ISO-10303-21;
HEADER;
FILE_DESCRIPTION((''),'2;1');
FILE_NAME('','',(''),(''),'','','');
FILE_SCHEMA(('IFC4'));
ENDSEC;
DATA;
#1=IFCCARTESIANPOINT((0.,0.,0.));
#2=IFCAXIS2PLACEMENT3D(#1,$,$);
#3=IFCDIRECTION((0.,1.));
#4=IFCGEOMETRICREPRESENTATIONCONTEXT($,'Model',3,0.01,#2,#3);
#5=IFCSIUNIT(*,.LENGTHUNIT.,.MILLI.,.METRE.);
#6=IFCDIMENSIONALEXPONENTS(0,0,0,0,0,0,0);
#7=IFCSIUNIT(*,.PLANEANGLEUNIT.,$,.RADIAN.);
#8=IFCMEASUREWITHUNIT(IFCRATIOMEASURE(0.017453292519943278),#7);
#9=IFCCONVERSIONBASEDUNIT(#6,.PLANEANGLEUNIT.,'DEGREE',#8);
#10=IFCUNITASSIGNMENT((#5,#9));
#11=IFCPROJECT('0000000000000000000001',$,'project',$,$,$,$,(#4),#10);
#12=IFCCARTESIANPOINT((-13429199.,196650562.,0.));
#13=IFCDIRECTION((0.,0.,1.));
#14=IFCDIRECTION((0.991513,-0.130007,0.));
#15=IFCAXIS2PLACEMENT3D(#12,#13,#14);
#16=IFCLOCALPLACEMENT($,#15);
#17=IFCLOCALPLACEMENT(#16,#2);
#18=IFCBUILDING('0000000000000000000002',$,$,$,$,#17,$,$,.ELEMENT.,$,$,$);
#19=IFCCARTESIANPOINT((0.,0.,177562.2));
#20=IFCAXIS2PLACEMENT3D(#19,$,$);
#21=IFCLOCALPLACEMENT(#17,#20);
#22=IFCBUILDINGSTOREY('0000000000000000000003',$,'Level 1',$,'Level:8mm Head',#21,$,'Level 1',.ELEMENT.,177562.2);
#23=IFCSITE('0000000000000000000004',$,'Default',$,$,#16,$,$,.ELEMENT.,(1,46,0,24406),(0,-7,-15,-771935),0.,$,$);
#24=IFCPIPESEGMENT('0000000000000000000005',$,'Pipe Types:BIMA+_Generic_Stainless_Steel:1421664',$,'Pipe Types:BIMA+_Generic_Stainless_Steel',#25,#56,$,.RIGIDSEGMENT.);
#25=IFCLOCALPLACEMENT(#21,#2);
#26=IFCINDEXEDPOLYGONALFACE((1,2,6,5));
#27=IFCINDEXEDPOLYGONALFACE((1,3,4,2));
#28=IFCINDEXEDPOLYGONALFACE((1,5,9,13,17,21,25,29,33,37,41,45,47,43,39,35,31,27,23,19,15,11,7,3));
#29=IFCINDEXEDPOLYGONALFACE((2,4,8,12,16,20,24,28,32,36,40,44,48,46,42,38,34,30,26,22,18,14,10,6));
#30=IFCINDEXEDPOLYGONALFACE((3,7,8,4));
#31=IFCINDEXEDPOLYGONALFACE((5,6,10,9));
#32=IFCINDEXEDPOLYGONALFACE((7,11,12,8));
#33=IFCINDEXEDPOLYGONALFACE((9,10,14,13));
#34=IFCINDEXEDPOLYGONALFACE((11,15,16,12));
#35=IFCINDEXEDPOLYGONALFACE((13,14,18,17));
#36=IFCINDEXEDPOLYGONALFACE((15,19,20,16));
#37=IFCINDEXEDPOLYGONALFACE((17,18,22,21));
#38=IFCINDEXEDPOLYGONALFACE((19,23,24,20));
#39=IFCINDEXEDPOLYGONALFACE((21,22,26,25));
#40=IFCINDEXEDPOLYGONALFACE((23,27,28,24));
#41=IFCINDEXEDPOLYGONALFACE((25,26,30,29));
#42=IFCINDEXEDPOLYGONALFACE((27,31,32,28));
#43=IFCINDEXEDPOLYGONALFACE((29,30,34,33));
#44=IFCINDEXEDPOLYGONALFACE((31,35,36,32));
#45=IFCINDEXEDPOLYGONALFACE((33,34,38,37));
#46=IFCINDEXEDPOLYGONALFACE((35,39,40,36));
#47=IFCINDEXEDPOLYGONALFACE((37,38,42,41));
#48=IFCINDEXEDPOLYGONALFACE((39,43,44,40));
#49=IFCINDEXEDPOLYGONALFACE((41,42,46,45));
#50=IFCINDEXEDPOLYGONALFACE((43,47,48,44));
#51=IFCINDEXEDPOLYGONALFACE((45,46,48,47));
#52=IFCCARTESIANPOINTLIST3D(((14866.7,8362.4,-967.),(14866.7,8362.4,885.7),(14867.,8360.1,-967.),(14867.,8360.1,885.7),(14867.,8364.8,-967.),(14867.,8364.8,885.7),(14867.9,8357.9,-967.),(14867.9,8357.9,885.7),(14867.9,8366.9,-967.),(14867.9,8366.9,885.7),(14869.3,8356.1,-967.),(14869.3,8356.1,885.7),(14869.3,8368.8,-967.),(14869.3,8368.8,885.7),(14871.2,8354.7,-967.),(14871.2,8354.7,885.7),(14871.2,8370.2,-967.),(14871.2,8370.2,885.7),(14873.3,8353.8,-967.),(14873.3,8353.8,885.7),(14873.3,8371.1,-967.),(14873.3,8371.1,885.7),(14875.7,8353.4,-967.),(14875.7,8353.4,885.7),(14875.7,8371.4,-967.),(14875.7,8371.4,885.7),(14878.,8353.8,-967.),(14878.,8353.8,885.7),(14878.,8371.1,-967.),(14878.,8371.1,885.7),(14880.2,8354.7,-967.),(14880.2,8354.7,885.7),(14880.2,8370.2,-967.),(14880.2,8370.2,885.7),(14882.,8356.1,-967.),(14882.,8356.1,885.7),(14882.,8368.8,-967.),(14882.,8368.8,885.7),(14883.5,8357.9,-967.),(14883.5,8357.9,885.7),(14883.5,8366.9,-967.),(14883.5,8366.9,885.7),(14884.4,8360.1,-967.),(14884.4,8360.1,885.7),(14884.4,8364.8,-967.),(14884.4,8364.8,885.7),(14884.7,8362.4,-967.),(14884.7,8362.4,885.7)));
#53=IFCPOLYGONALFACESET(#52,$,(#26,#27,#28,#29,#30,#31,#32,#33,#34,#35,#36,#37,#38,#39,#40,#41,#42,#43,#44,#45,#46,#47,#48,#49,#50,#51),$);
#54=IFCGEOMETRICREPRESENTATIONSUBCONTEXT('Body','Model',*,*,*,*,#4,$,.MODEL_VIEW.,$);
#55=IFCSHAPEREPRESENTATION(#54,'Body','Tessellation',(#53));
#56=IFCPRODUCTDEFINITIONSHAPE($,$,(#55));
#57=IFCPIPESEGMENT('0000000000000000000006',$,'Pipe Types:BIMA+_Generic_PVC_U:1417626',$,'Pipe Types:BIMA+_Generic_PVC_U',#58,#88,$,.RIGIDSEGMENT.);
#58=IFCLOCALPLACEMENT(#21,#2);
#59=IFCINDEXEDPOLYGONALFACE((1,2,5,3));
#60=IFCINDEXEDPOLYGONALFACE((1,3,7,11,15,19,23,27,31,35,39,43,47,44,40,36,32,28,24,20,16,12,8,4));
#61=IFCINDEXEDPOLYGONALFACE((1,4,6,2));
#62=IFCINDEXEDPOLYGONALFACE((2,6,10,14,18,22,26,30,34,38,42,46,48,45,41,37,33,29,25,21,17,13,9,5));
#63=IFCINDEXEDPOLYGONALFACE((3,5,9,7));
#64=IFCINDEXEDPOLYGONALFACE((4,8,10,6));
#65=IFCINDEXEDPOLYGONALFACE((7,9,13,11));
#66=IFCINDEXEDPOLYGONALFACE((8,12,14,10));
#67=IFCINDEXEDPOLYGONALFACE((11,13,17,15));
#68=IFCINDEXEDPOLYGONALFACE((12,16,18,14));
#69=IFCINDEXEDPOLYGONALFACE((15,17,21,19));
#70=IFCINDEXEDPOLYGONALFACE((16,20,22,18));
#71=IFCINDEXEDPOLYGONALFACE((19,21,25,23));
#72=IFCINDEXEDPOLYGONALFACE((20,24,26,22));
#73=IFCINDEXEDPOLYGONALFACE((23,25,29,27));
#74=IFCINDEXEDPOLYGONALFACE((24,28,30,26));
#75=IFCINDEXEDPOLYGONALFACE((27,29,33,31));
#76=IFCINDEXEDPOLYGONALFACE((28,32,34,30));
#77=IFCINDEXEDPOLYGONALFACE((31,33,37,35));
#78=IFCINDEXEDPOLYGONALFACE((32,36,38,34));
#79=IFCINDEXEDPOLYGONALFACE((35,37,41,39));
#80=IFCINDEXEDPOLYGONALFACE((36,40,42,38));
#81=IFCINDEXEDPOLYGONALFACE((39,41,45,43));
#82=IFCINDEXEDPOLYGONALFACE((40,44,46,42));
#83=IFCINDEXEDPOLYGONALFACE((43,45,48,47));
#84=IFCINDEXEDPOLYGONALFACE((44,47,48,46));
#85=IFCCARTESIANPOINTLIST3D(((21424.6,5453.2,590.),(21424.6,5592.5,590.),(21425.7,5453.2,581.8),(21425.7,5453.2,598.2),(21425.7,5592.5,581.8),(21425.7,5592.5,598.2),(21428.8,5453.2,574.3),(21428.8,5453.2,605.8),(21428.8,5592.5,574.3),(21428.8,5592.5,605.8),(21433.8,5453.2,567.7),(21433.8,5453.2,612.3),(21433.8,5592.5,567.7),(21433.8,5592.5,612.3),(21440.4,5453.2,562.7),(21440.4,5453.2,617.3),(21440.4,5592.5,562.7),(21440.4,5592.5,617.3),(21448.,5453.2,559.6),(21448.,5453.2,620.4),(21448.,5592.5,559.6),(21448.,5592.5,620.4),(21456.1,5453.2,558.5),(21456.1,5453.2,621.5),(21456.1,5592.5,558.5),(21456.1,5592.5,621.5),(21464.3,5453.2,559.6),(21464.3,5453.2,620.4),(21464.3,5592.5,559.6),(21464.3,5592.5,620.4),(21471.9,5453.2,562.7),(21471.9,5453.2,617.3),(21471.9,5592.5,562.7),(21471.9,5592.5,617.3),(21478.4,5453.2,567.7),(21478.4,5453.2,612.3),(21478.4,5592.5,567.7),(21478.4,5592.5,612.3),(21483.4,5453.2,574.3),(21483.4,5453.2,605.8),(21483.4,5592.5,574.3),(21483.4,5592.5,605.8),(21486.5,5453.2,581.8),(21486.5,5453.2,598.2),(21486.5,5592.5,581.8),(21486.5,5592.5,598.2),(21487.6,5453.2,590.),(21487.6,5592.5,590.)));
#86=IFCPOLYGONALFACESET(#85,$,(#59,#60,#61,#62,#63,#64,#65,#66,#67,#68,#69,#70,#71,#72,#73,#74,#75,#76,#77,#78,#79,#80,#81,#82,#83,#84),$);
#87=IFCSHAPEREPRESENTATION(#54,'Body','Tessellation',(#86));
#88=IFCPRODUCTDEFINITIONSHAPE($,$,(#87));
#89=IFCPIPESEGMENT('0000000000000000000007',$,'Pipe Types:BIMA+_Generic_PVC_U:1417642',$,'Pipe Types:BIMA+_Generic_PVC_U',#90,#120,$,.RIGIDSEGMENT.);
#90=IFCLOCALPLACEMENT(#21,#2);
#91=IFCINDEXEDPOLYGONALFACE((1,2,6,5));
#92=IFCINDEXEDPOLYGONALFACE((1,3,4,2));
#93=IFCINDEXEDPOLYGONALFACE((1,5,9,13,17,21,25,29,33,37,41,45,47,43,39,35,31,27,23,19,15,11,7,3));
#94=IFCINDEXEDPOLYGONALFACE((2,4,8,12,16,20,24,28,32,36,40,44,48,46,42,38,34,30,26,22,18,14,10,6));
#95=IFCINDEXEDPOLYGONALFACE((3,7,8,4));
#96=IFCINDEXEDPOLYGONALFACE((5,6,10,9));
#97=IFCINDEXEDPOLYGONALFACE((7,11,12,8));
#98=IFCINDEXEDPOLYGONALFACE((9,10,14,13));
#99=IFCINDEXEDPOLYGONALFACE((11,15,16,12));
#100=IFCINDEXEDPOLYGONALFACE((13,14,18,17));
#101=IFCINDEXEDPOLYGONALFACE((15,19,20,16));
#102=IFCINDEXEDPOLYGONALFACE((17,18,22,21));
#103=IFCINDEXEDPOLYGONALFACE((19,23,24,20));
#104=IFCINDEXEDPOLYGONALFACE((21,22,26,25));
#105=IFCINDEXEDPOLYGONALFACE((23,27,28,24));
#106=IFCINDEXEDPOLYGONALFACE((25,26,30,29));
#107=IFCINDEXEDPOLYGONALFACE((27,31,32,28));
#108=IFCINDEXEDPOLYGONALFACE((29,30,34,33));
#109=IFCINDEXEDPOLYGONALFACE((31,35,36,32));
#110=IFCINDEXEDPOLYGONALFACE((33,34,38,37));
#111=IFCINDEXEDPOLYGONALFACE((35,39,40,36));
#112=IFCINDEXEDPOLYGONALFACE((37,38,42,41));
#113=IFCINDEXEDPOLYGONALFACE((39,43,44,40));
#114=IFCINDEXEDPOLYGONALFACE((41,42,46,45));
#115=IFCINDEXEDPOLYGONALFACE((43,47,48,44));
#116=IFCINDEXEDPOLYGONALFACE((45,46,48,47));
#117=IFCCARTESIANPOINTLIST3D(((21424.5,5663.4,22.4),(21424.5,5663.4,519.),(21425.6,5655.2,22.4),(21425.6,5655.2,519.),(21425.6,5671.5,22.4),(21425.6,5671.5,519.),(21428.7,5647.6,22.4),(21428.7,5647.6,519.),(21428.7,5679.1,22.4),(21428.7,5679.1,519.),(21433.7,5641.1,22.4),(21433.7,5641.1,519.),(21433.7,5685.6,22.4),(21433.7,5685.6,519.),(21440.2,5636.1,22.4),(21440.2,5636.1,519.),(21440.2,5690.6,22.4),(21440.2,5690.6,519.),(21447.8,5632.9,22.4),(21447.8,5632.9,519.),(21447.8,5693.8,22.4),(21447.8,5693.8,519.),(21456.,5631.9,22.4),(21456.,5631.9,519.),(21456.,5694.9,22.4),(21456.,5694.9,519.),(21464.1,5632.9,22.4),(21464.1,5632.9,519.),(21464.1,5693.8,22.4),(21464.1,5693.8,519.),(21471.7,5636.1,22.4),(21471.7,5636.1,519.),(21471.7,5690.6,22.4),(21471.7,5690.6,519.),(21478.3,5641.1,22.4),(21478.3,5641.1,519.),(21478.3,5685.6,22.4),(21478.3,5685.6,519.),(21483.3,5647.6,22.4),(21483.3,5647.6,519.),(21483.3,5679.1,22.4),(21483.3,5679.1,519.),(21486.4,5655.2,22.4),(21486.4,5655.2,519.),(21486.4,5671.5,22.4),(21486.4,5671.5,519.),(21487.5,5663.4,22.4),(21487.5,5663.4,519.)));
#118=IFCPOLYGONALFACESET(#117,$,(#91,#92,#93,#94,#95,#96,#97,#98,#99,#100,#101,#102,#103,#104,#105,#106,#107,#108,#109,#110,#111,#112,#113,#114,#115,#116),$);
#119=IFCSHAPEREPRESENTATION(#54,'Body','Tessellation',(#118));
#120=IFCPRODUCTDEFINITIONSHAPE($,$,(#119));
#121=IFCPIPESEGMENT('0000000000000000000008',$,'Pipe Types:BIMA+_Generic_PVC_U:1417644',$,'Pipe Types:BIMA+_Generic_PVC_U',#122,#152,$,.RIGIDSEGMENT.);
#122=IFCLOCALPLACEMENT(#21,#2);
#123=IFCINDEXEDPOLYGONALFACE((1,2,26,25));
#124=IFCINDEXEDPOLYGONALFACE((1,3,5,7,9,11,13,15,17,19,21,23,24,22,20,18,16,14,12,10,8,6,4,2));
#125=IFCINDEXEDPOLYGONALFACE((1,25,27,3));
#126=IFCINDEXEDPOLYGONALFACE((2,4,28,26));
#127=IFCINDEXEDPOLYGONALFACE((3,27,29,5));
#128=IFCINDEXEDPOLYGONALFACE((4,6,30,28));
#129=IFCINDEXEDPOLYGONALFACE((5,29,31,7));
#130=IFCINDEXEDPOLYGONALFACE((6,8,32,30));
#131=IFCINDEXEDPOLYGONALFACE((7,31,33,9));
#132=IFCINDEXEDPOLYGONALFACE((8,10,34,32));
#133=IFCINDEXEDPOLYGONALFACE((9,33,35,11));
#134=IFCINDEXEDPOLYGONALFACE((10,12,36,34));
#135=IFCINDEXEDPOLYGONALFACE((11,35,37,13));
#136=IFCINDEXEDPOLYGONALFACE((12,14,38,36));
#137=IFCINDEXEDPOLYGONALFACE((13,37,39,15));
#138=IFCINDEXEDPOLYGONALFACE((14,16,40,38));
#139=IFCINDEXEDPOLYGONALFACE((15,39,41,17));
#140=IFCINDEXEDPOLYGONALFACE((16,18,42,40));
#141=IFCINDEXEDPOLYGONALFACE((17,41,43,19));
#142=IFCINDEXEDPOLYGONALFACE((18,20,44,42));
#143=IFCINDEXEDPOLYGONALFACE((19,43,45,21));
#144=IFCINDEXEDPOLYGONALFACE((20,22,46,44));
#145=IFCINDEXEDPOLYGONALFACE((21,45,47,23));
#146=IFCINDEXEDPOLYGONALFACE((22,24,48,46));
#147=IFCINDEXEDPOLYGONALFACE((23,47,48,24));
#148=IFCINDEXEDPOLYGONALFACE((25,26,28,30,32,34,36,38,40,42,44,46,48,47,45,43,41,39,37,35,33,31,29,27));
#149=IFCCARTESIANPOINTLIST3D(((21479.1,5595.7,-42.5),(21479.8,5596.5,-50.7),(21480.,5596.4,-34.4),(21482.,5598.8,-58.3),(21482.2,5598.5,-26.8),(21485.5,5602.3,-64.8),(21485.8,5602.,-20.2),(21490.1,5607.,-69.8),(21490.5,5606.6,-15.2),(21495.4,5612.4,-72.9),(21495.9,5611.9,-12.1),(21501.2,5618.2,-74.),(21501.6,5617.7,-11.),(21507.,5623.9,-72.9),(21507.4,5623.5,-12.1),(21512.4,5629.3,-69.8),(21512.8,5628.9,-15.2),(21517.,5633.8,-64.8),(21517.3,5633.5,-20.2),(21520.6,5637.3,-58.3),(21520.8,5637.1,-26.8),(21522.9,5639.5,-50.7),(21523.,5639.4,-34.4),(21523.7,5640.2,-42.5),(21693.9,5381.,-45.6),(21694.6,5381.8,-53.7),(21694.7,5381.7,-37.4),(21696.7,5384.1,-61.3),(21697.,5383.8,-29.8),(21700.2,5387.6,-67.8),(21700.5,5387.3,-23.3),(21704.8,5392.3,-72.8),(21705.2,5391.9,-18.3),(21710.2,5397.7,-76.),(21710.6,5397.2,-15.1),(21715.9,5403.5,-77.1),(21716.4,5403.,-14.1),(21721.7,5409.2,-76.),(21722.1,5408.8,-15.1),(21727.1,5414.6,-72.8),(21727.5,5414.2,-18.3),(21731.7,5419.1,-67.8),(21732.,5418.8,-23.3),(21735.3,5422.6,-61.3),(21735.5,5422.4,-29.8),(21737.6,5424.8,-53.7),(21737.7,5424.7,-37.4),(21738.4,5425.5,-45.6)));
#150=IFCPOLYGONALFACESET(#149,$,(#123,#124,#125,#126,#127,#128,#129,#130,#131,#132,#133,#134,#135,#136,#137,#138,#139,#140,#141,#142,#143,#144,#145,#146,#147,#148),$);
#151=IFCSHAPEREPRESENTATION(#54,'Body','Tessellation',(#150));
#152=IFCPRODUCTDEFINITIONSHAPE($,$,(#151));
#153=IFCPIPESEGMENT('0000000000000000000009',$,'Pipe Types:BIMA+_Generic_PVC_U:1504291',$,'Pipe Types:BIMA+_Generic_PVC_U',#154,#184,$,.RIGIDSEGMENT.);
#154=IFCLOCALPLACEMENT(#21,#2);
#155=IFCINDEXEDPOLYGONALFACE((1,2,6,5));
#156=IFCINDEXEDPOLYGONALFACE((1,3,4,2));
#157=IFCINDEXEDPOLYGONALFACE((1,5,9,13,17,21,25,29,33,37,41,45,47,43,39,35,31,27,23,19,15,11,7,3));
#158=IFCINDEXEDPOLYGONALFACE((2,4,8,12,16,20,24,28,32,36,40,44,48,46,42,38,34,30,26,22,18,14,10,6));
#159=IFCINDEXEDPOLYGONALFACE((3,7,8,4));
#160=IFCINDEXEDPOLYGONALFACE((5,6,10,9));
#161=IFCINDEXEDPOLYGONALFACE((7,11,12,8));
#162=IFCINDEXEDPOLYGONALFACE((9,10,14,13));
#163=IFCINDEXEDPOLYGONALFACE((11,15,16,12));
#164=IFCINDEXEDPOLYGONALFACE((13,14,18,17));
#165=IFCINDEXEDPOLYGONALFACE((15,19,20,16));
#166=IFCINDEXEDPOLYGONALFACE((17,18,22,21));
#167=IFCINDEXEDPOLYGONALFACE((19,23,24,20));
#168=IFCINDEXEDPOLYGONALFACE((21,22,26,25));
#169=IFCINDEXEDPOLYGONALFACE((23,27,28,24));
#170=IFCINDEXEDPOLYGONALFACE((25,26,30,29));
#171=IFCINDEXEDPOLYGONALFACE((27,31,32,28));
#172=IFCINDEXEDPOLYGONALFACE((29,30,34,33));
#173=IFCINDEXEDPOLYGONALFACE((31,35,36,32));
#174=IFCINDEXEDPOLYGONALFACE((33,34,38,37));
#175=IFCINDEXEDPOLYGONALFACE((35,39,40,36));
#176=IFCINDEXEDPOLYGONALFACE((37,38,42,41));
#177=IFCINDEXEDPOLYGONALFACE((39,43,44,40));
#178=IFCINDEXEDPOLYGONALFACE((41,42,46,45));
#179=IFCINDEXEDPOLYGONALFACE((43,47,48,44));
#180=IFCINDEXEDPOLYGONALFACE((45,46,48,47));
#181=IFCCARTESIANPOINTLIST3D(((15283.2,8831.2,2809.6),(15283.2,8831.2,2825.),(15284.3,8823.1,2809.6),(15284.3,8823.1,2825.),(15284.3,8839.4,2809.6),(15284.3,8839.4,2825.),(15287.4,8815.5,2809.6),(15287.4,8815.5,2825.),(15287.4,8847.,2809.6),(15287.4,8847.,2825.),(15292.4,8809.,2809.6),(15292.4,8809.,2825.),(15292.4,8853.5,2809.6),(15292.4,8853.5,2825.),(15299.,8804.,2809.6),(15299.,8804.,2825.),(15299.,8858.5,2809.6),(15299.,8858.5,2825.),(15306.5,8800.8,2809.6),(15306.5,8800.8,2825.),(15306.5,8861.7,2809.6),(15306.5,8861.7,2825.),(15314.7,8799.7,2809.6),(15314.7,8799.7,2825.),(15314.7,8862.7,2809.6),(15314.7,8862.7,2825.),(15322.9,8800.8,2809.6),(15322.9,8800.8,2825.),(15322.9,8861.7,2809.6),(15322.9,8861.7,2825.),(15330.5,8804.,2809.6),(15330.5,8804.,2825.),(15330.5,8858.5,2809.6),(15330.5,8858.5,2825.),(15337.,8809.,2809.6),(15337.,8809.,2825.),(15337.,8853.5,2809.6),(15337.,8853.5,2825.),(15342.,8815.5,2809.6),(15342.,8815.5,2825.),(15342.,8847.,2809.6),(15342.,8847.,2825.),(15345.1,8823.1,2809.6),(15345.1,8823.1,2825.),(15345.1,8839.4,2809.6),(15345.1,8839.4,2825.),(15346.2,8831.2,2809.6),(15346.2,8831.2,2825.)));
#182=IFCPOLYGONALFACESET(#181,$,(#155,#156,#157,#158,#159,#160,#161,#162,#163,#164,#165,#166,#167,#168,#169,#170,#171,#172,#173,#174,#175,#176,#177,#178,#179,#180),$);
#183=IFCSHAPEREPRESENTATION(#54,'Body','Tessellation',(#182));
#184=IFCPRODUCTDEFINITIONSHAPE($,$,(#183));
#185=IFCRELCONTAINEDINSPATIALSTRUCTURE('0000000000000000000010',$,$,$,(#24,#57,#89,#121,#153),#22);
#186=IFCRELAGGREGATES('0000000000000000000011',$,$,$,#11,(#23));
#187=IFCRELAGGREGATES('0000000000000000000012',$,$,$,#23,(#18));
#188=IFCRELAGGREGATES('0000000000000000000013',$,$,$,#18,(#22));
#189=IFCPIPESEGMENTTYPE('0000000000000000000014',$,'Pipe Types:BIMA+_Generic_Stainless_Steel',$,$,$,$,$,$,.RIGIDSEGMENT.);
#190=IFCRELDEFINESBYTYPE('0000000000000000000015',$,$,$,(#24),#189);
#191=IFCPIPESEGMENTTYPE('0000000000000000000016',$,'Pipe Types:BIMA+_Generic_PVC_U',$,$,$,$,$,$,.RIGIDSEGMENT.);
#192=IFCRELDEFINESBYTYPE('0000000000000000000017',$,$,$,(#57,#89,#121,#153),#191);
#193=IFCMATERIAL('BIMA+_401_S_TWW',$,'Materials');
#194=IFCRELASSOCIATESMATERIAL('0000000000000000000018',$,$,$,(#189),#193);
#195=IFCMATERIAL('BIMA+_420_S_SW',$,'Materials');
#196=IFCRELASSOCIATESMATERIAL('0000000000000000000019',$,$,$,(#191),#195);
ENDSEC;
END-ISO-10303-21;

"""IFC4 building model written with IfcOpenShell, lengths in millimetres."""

from ifc_helpers import new_model, entity, si_unit, converted_unit, direction, frame, origin, place, context, subcontext, project, spatial, arc, indexed_curve, outline, extrude, material, type_object, element, save


model = new_model("IFC4")

# Units and contexts
model_context = context("Model", 3, precision=0.01, world=origin(), true_north=direction((0.0, 1.0)))
body_context = subcontext(model_context, "Body", "Model", "MODEL_VIEW")
ifc_project = project(units=[si_unit("LENGTHUNIT", "METRE", prefix="MILLI"), converted_unit("PLANEANGLEUNIT", "DEGREE", entity("IfcRatioMeasure", 0.017453292519943278), si_unit("PLANEANGLEUNIT", "RADIAN"), dimensions=[0, 0, 0, 0, 0, 0, 0])], contexts=[model_context])

# Site, building, storey
site_placement = place(None, frame((-13429199.0, 196650562.0, 0.0), z_axis=(0.0, 0.0, 1.0), x_axis=(0.991513, -0.130007, 0.0)))
site = spatial("IfcSite", under=ifc_project, at=site_placement, Name="Default", CompositionType="ELEMENT", RefLatitude=(1, 46, 0, 24406), RefLongitude=(0, -7, -15, -771935), RefElevation=0.0)
building_placement = place(site_placement, origin())
building = spatial("IfcBuilding", under=site, at=building_placement, CompositionType="ELEMENT")
storey_placement = place(building_placement, frame((0.0, 0.0, 177562.2)))
storey = spatial("IfcBuildingStorey", under=building, at=storey_placement, Name="Level 1", ObjectType="Level:8mm Head", LongName="Level 1", CompositionType="ELEMENT", Elevation=177562.2)

# Pipe segments
ifc_material_1 = material(Name="BIMA+_401_S_TWW", Category="Materials")
pipe_segment_type_1 = type_object("IfcPipeSegmentType", Name="Pipe Types:BIMA+_Generic_Stainless_Steel", PredefinedType="RIGIDSEGMENT", material=ifc_material_1)
pipe_segment_1_placement = place(storey_placement, frame((14865.1, 8351.9, -967.0)))
element("IfcPipeSegment", 1, at=pipe_segment_1_placement, inside=storey, type_object=pipe_segment_type_1, Name="Pipe Types:BIMA+_Generic_Stainless_Steel:1421664", ObjectType="Pipe Types:BIMA+_Generic_Stainless_Steel", PredefinedType="RIGIDSEGMENT", context=body_context, shape_type="SweptSolid", body=[
    extrude(outline(indexed_curve([(9.0, 0.0), (6.4, 6.4), (0.0, 9.0), (-6.4, 6.4), (-9.0, 0.0), (-6.4, -6.4), (0.0, -9.0), (6.4, -6.4)], segments=[arc(1, 2, 3), arc(3, 4, 5), arc(5, 6, 7), arc(7, 8, 1)], self_intersect=False)), frame((10.6, 10.6, 0.0)), (0.0, 0.0, 1.0), 1852.7),
])
ifc_material_2 = material(Name="BIMA+_420_S_SW", Category="Materials")
pipe_segment_type_2 = type_object("IfcPipeSegmentType", Name="Pipe Types:BIMA+_Generic_PVC_U", PredefinedType="RIGIDSEGMENT", material=ifc_material_2)
pipe_segment_2_placement = place(storey_placement, frame((21423.0, 5453.2, 556.9)))
element("IfcPipeSegment", 2, at=pipe_segment_2_placement, inside=storey, type_object=pipe_segment_type_2, Name="Pipe Types:BIMA+_Generic_PVC_U:1417626", ObjectType="Pipe Types:BIMA+_Generic_PVC_U", PredefinedType="RIGIDSEGMENT", context=body_context, shape_type="SweptSolid", body=[
    extrude(outline(indexed_curve([(31.5, 0.0), (22.3, 22.3), (0.0, 31.5), (-22.3, 22.3), (-31.5, 0.0), (-22.3, -22.3), (0.0, -31.5), (22.3, -22.3)], segments=[arc(1, 2, 3), arc(3, 4, 5), arc(5, 6, 7), arc(7, 8, 1)], self_intersect=False)), frame((33.1, 0.0, 33.1), z_axis=(0.0, 1.0, 0.0), x_axis=(1.0, 0.0, 0.0)), (0.0, 0.0, 1.0), 139.3),
])
pipe_segment_3_placement = place(storey_placement, frame((21422.9, 5630.3, 22.4)))
element("IfcPipeSegment", 3, at=pipe_segment_3_placement, inside=storey, type_object=pipe_segment_type_2, Name="Pipe Types:BIMA+_Generic_PVC_U:1417642", ObjectType="Pipe Types:BIMA+_Generic_PVC_U", PredefinedType="RIGIDSEGMENT", context=body_context, shape_type="SweptSolid", body=[
    extrude(outline(indexed_curve([(31.5, 0.0), (22.3, 22.3), (0.0, 31.5), (-22.3, 22.3), (-31.5, 0.0), (-22.3, -22.3), (0.0, -31.5), (22.3, -22.3)], segments=[arc(1, 2, 3), arc(3, 4, 5), arc(5, 6, 7), arc(7, 8, 1)], self_intersect=False)), frame((33.1, 33.1, 0.0)), (0.0, 0.0, 1.0), 496.6),
])
pipe_segment_4_placement = place(storey_placement, frame((21477.6, 5379.4, -9.4)))
element("IfcPipeSegment", 4, at=pipe_segment_4_placement, inside=storey, type_object=pipe_segment_type_2, Name="Pipe Types:BIMA+_Generic_PVC_U:1417644", ObjectType="Pipe Types:BIMA+_Generic_PVC_U", PredefinedType="RIGIDSEGMENT", context=body_context, shape_type="SweptSolid", body=[
    extrude(outline(indexed_curve([(31.5, 0.0), (22.3, 22.3), (0.0, 31.5), (-22.3, 22.3), (-31.5, 0.0), (-22.3, -22.3), (0.0, -31.5), (22.3, -22.3)], segments=[arc(1, 2, 3), arc(3, 4, 5), arc(5, 6, 7), arc(7, 8, 1)], self_intersect=False)), frame((238.6, 23.9, -36.1), z_axis=(-0.707107, 0.707036, 0.010047), x_axis=(0.707071, 0.707142, 0.0)), (0.0, 0.0, 1.0), 303.7),
])
pipe_segment_5_placement = place(storey_placement, frame((15281.6, 8798.2, 2809.6)))
element("IfcPipeSegment", 5, at=pipe_segment_5_placement, inside=storey, type_object=pipe_segment_type_2, Name="Pipe Types:BIMA+_Generic_PVC_U:1504291", ObjectType="Pipe Types:BIMA+_Generic_PVC_U", PredefinedType="RIGIDSEGMENT", context=body_context, shape_type="SweptSolid", body=[
    extrude(outline(indexed_curve([(31.5, 0.0), (22.3, 22.3), (0.0, 31.5), (-22.3, 22.3), (-31.5, 0.0), (-22.3, -22.3), (0.0, -31.5), (22.3, -22.3)], segments=[arc(1, 2, 3), arc(3, 4, 5), arc(5, 6, 7), arc(7, 8, 1)], self_intersect=False)), frame((33.1, 33.1, 0.0)), (0.0, 0.0, 1.0), 15.4),
])

save(model, "model.ifc")
